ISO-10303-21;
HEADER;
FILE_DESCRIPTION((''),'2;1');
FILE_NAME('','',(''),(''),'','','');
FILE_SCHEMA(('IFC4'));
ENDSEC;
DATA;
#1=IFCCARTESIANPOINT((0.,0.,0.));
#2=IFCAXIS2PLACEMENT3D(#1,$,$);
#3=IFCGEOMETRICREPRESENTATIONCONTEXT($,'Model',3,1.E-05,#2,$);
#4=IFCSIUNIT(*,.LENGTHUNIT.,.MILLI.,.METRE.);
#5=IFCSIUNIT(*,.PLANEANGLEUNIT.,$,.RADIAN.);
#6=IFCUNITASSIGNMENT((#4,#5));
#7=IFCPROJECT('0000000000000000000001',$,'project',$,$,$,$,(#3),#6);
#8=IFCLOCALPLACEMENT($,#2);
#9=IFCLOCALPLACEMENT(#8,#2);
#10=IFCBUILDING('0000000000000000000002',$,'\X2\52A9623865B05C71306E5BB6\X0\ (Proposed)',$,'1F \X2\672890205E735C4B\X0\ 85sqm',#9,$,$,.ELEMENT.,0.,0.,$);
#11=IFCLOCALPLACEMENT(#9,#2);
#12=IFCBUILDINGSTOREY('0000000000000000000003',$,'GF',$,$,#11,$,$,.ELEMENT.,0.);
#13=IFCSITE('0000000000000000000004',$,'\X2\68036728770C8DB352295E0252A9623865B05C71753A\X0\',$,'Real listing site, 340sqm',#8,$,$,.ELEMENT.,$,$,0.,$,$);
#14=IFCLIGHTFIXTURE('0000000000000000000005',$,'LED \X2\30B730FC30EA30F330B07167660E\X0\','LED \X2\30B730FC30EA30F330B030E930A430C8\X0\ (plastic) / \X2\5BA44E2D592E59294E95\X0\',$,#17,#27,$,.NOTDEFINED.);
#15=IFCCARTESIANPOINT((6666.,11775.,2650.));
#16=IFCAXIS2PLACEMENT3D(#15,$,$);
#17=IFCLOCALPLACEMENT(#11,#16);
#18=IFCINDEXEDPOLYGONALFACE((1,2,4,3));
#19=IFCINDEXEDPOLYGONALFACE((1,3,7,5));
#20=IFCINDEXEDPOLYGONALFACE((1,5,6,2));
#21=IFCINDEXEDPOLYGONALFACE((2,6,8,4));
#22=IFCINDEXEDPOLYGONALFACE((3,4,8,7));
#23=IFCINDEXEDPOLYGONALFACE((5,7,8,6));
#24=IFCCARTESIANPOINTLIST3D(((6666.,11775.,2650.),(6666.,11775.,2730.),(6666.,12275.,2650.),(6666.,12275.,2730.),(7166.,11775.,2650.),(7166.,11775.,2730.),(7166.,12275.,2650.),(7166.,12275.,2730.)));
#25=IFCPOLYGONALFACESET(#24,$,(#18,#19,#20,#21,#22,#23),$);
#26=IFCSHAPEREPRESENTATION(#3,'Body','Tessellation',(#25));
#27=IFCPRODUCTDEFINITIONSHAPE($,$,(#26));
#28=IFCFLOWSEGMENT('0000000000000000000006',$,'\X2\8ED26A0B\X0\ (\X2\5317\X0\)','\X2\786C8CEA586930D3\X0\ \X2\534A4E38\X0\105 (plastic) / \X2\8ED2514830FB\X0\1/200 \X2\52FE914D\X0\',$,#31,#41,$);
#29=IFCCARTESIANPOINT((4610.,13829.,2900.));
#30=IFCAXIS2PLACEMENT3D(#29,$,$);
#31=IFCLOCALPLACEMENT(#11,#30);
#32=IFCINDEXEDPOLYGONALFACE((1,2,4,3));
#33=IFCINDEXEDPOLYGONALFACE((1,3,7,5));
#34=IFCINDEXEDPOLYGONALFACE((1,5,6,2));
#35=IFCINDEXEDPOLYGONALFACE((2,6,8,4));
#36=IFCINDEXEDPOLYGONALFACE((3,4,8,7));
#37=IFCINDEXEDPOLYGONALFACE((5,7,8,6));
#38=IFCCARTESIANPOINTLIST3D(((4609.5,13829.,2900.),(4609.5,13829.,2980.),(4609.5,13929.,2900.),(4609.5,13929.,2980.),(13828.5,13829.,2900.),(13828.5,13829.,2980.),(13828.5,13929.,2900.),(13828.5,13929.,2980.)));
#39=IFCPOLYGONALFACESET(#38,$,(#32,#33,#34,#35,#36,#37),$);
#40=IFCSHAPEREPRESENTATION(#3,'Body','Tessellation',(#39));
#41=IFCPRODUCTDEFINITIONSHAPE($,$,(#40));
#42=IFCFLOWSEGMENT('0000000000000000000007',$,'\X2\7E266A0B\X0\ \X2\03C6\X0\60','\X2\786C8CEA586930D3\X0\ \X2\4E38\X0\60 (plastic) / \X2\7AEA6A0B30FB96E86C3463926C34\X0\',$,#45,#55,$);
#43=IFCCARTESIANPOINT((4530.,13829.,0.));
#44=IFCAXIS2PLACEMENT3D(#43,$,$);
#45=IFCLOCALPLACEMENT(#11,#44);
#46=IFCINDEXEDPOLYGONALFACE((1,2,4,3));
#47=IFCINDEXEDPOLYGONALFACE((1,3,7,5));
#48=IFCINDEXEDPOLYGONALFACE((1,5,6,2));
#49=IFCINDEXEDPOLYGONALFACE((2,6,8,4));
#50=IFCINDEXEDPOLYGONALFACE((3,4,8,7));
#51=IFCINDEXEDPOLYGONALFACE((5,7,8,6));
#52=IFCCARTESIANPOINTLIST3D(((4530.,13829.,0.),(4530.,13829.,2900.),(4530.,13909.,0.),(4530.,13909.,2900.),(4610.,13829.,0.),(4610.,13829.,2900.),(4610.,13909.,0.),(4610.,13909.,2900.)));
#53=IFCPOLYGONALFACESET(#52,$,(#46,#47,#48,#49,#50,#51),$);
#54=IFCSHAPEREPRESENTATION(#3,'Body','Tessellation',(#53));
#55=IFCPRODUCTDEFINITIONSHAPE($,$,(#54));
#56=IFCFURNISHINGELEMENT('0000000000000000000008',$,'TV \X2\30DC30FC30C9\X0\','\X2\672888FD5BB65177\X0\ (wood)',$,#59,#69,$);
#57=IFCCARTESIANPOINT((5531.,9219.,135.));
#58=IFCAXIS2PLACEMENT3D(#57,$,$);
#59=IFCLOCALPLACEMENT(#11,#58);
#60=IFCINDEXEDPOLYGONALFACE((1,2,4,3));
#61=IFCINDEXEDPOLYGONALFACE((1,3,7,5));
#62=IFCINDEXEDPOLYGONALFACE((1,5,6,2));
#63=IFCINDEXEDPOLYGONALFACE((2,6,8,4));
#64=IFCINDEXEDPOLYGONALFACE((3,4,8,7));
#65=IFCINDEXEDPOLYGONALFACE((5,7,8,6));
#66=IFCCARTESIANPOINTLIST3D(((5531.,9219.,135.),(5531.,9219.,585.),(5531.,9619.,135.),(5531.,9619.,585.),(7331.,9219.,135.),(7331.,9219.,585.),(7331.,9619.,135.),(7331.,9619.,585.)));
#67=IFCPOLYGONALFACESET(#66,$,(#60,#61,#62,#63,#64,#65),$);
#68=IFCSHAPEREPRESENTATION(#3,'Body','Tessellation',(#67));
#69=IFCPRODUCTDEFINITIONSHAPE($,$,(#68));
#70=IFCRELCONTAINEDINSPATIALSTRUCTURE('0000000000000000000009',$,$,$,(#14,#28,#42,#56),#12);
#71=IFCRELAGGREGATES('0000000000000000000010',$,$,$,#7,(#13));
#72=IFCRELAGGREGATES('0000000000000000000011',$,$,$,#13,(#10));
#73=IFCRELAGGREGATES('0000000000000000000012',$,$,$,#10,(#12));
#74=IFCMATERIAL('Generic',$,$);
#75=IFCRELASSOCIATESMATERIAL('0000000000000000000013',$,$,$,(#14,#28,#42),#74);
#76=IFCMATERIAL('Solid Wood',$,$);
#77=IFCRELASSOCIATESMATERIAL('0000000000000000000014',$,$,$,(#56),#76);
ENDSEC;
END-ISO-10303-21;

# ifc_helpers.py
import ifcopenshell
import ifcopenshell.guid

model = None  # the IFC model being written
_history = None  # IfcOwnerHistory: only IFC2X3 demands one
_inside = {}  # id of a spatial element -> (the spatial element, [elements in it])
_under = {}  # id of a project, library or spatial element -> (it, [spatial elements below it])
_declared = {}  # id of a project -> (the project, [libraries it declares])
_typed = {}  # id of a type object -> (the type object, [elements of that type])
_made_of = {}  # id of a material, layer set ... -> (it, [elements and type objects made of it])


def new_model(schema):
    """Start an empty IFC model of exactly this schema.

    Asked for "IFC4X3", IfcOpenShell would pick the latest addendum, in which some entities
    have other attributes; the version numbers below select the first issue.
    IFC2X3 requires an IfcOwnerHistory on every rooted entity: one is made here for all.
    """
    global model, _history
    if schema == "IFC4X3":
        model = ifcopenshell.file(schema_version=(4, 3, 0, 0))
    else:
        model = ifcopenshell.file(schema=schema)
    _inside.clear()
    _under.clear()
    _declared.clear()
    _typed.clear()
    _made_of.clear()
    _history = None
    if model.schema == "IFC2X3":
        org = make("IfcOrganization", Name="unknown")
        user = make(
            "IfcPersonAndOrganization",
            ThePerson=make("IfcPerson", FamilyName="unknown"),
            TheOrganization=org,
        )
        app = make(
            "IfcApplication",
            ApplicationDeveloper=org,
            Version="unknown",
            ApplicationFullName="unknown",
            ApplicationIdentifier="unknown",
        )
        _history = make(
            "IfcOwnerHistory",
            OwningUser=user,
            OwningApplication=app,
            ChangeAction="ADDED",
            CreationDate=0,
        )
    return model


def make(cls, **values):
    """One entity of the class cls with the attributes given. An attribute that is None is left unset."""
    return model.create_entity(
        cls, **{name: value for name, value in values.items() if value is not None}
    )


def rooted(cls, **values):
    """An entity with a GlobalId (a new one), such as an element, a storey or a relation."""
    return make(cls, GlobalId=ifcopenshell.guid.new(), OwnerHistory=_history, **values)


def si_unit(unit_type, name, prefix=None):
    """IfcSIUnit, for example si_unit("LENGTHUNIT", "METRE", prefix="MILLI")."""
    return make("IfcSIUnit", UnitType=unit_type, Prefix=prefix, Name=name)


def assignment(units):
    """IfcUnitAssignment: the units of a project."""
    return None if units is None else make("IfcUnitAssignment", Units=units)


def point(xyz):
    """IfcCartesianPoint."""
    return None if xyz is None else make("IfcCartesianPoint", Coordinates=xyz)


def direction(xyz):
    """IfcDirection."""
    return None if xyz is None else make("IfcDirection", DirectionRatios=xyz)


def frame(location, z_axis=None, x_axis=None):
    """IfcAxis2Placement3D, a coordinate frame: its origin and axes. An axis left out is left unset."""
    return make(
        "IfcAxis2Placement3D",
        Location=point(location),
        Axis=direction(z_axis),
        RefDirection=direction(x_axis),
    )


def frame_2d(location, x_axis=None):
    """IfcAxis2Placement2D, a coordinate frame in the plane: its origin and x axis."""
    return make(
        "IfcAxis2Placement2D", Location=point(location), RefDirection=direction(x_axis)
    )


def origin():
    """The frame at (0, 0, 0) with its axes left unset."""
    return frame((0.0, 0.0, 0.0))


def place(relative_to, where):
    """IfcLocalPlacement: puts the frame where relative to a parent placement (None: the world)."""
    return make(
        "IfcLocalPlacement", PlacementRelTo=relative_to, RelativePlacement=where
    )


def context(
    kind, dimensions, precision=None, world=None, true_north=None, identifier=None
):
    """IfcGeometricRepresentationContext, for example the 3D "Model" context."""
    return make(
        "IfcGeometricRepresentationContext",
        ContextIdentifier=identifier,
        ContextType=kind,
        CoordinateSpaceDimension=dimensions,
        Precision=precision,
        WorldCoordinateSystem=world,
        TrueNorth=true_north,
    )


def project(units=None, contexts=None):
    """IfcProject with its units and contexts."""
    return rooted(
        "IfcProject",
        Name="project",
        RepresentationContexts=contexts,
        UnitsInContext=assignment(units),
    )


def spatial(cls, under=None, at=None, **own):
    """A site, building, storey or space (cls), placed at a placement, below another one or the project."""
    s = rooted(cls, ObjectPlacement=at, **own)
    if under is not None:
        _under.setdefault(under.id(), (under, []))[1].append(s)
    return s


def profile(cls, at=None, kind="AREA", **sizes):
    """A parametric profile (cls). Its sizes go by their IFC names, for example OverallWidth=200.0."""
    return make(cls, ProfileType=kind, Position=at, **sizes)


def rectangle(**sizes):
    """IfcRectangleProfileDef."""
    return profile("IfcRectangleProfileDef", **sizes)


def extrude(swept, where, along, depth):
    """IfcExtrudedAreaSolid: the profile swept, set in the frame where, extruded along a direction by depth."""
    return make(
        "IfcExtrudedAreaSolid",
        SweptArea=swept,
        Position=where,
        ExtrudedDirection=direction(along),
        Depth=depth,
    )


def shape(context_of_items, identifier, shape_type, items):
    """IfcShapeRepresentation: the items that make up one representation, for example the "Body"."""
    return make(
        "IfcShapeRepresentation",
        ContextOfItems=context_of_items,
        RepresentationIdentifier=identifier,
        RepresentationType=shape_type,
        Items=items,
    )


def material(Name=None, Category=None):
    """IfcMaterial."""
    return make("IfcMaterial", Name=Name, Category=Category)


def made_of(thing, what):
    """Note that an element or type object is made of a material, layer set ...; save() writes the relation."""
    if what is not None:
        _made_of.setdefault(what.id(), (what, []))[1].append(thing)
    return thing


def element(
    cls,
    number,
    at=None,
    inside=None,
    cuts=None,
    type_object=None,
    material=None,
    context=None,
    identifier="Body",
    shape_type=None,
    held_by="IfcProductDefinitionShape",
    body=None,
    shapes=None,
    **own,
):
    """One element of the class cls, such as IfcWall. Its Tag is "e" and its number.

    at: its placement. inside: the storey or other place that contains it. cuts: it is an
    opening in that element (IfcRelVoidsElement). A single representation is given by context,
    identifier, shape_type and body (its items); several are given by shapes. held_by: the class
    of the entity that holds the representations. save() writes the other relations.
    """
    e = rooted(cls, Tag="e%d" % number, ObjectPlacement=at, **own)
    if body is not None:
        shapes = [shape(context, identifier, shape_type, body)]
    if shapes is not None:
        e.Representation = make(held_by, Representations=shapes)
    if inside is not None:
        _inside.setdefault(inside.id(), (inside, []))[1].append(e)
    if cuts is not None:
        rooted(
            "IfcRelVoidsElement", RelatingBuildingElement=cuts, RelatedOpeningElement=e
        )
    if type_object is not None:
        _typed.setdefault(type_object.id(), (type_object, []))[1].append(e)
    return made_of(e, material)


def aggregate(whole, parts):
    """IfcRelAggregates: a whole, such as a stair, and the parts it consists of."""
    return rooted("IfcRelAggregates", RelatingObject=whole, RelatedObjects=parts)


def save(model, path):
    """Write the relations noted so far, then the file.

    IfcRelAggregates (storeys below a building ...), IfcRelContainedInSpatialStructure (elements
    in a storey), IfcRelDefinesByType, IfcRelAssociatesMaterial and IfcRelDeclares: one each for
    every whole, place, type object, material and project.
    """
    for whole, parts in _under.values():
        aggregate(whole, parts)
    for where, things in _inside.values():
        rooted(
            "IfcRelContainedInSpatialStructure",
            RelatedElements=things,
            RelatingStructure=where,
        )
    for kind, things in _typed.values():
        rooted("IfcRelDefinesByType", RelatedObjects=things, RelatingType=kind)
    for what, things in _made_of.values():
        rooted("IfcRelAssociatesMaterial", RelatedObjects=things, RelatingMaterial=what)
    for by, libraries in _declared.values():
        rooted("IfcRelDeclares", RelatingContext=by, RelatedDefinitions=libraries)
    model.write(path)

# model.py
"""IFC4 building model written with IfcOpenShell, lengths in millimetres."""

from ifc_helpers import new_model, si_unit, frame, frame_2d, origin, place, context, project, spatial, rectangle, extrude, material, element, save


model = new_model("IFC4")

# Units and contexts
model_context = context("Model", 3, precision=1e-05, world=origin())
ifc_project = project(units=[si_unit("LENGTHUNIT", "METRE", prefix="MILLI"), si_unit("PLANEANGLEUNIT", "RADIAN")], contexts=[model_context])

# Site, building, storey
site_placement = place(None, origin())
site = spatial("IfcSite", under=ifc_project, at=site_placement, Name="栃木県足利市助戸新山町", ObjectType="Real listing site, 340sqm", CompositionType="ELEMENT", RefElevation=0.0)
building_placement = place(site_placement, origin())
building = spatial("IfcBuilding", under=site, at=building_placement, Name="助戸新山の家 (Proposed)", ObjectType="1F 木造平屋 85sqm", CompositionType="ELEMENT", ElevationOfRefHeight=0.0, ElevationOfTerrain=0.0)
storey_placement = place(building_placement, origin())
storey = spatial("IfcBuildingStorey", under=building, at=storey_placement, Name="GF", CompositionType="ELEMENT", Elevation=0.0)

# Shared definitions
ifc_material_1 = material(Name="Solid Wood")

# Shared definitions
ifc_material_2 = material(Name="Generic")

# Light fixture
light_fixture_placement = place(storey_placement, frame((6666.0, 11775.0, 2650.0)))
element("IfcLightFixture", 1, at=light_fixture_placement, inside=storey, material=ifc_material_2, Name="LED シーリング照明", Description="LED シーリングライト (plastic) / 室中央天井", PredefinedType="NOTDEFINED", context=model_context, shape_type="SweptSolid", body=[
    extrude(rectangle(XDim=500.0, YDim=500.0, at=frame_2d((250.0, 250.0))), frame((6666.0, 11775.0, 2650.0)), (0.0, 0.0, 1.0), 80.0),
])

# Flow segments
flow_segment_1_placement = place(storey_placement, frame((4610.0, 13829.0, 2900.0)))
element("IfcFlowSegment", 2, at=flow_segment_1_placement, inside=storey, material=ifc_material_2, Name="軒樋 (北)", Description="硬質塩ビ 半丸105 (plastic) / 軒先・1/200 勾配", context=model_context, shape_type="SweptSolid", body=[
    extrude(rectangle(XDim=9219.0, YDim=100.0, at=frame_2d((4609.0, 50.0))), frame((4610.0, 13829.0, 2900.0)), (0.0, 0.0, 1.0), 80.0),
])
flow_segment_2_placement = place(storey_placement, frame((4530.0, 13829.0, 0.0)))
element("IfcFlowSegment", 3, at=flow_segment_2_placement, inside=storey, material=ifc_material_2, Name="縦樋 φ60", Description="硬質塩ビ 丸60 (plastic) / 竪樋・雨水排水", context=model_context, shape_type="SweptSolid", body=[
    extrude(rectangle(XDim=80.0, YDim=80.0, at=frame_2d((40.0, 40.0))), frame((4530.0, 13829.0, 0.0)), (0.0, 0.0, 1.0), 2900.0),
])

# Furnishing element
furnishing_placement = place(storey_placement, frame((5531.0, 9219.0, 135.0)))
element("IfcFurnishingElement", 4, at=furnishing_placement, inside=storey, material=ifc_material_1, Name="TV ボード", Description="木製家具 (wood)", context=model_context, shape_type="SweptSolid", body=[
    extrude(rectangle(XDim=1800.0, YDim=400.0, at=frame_2d((900.0, 200.0))), frame((5531.0, 9219.0, 135.0)), (0.0, 0.0, 1.0), 450.0),
])

save(model, "model.ifc")
